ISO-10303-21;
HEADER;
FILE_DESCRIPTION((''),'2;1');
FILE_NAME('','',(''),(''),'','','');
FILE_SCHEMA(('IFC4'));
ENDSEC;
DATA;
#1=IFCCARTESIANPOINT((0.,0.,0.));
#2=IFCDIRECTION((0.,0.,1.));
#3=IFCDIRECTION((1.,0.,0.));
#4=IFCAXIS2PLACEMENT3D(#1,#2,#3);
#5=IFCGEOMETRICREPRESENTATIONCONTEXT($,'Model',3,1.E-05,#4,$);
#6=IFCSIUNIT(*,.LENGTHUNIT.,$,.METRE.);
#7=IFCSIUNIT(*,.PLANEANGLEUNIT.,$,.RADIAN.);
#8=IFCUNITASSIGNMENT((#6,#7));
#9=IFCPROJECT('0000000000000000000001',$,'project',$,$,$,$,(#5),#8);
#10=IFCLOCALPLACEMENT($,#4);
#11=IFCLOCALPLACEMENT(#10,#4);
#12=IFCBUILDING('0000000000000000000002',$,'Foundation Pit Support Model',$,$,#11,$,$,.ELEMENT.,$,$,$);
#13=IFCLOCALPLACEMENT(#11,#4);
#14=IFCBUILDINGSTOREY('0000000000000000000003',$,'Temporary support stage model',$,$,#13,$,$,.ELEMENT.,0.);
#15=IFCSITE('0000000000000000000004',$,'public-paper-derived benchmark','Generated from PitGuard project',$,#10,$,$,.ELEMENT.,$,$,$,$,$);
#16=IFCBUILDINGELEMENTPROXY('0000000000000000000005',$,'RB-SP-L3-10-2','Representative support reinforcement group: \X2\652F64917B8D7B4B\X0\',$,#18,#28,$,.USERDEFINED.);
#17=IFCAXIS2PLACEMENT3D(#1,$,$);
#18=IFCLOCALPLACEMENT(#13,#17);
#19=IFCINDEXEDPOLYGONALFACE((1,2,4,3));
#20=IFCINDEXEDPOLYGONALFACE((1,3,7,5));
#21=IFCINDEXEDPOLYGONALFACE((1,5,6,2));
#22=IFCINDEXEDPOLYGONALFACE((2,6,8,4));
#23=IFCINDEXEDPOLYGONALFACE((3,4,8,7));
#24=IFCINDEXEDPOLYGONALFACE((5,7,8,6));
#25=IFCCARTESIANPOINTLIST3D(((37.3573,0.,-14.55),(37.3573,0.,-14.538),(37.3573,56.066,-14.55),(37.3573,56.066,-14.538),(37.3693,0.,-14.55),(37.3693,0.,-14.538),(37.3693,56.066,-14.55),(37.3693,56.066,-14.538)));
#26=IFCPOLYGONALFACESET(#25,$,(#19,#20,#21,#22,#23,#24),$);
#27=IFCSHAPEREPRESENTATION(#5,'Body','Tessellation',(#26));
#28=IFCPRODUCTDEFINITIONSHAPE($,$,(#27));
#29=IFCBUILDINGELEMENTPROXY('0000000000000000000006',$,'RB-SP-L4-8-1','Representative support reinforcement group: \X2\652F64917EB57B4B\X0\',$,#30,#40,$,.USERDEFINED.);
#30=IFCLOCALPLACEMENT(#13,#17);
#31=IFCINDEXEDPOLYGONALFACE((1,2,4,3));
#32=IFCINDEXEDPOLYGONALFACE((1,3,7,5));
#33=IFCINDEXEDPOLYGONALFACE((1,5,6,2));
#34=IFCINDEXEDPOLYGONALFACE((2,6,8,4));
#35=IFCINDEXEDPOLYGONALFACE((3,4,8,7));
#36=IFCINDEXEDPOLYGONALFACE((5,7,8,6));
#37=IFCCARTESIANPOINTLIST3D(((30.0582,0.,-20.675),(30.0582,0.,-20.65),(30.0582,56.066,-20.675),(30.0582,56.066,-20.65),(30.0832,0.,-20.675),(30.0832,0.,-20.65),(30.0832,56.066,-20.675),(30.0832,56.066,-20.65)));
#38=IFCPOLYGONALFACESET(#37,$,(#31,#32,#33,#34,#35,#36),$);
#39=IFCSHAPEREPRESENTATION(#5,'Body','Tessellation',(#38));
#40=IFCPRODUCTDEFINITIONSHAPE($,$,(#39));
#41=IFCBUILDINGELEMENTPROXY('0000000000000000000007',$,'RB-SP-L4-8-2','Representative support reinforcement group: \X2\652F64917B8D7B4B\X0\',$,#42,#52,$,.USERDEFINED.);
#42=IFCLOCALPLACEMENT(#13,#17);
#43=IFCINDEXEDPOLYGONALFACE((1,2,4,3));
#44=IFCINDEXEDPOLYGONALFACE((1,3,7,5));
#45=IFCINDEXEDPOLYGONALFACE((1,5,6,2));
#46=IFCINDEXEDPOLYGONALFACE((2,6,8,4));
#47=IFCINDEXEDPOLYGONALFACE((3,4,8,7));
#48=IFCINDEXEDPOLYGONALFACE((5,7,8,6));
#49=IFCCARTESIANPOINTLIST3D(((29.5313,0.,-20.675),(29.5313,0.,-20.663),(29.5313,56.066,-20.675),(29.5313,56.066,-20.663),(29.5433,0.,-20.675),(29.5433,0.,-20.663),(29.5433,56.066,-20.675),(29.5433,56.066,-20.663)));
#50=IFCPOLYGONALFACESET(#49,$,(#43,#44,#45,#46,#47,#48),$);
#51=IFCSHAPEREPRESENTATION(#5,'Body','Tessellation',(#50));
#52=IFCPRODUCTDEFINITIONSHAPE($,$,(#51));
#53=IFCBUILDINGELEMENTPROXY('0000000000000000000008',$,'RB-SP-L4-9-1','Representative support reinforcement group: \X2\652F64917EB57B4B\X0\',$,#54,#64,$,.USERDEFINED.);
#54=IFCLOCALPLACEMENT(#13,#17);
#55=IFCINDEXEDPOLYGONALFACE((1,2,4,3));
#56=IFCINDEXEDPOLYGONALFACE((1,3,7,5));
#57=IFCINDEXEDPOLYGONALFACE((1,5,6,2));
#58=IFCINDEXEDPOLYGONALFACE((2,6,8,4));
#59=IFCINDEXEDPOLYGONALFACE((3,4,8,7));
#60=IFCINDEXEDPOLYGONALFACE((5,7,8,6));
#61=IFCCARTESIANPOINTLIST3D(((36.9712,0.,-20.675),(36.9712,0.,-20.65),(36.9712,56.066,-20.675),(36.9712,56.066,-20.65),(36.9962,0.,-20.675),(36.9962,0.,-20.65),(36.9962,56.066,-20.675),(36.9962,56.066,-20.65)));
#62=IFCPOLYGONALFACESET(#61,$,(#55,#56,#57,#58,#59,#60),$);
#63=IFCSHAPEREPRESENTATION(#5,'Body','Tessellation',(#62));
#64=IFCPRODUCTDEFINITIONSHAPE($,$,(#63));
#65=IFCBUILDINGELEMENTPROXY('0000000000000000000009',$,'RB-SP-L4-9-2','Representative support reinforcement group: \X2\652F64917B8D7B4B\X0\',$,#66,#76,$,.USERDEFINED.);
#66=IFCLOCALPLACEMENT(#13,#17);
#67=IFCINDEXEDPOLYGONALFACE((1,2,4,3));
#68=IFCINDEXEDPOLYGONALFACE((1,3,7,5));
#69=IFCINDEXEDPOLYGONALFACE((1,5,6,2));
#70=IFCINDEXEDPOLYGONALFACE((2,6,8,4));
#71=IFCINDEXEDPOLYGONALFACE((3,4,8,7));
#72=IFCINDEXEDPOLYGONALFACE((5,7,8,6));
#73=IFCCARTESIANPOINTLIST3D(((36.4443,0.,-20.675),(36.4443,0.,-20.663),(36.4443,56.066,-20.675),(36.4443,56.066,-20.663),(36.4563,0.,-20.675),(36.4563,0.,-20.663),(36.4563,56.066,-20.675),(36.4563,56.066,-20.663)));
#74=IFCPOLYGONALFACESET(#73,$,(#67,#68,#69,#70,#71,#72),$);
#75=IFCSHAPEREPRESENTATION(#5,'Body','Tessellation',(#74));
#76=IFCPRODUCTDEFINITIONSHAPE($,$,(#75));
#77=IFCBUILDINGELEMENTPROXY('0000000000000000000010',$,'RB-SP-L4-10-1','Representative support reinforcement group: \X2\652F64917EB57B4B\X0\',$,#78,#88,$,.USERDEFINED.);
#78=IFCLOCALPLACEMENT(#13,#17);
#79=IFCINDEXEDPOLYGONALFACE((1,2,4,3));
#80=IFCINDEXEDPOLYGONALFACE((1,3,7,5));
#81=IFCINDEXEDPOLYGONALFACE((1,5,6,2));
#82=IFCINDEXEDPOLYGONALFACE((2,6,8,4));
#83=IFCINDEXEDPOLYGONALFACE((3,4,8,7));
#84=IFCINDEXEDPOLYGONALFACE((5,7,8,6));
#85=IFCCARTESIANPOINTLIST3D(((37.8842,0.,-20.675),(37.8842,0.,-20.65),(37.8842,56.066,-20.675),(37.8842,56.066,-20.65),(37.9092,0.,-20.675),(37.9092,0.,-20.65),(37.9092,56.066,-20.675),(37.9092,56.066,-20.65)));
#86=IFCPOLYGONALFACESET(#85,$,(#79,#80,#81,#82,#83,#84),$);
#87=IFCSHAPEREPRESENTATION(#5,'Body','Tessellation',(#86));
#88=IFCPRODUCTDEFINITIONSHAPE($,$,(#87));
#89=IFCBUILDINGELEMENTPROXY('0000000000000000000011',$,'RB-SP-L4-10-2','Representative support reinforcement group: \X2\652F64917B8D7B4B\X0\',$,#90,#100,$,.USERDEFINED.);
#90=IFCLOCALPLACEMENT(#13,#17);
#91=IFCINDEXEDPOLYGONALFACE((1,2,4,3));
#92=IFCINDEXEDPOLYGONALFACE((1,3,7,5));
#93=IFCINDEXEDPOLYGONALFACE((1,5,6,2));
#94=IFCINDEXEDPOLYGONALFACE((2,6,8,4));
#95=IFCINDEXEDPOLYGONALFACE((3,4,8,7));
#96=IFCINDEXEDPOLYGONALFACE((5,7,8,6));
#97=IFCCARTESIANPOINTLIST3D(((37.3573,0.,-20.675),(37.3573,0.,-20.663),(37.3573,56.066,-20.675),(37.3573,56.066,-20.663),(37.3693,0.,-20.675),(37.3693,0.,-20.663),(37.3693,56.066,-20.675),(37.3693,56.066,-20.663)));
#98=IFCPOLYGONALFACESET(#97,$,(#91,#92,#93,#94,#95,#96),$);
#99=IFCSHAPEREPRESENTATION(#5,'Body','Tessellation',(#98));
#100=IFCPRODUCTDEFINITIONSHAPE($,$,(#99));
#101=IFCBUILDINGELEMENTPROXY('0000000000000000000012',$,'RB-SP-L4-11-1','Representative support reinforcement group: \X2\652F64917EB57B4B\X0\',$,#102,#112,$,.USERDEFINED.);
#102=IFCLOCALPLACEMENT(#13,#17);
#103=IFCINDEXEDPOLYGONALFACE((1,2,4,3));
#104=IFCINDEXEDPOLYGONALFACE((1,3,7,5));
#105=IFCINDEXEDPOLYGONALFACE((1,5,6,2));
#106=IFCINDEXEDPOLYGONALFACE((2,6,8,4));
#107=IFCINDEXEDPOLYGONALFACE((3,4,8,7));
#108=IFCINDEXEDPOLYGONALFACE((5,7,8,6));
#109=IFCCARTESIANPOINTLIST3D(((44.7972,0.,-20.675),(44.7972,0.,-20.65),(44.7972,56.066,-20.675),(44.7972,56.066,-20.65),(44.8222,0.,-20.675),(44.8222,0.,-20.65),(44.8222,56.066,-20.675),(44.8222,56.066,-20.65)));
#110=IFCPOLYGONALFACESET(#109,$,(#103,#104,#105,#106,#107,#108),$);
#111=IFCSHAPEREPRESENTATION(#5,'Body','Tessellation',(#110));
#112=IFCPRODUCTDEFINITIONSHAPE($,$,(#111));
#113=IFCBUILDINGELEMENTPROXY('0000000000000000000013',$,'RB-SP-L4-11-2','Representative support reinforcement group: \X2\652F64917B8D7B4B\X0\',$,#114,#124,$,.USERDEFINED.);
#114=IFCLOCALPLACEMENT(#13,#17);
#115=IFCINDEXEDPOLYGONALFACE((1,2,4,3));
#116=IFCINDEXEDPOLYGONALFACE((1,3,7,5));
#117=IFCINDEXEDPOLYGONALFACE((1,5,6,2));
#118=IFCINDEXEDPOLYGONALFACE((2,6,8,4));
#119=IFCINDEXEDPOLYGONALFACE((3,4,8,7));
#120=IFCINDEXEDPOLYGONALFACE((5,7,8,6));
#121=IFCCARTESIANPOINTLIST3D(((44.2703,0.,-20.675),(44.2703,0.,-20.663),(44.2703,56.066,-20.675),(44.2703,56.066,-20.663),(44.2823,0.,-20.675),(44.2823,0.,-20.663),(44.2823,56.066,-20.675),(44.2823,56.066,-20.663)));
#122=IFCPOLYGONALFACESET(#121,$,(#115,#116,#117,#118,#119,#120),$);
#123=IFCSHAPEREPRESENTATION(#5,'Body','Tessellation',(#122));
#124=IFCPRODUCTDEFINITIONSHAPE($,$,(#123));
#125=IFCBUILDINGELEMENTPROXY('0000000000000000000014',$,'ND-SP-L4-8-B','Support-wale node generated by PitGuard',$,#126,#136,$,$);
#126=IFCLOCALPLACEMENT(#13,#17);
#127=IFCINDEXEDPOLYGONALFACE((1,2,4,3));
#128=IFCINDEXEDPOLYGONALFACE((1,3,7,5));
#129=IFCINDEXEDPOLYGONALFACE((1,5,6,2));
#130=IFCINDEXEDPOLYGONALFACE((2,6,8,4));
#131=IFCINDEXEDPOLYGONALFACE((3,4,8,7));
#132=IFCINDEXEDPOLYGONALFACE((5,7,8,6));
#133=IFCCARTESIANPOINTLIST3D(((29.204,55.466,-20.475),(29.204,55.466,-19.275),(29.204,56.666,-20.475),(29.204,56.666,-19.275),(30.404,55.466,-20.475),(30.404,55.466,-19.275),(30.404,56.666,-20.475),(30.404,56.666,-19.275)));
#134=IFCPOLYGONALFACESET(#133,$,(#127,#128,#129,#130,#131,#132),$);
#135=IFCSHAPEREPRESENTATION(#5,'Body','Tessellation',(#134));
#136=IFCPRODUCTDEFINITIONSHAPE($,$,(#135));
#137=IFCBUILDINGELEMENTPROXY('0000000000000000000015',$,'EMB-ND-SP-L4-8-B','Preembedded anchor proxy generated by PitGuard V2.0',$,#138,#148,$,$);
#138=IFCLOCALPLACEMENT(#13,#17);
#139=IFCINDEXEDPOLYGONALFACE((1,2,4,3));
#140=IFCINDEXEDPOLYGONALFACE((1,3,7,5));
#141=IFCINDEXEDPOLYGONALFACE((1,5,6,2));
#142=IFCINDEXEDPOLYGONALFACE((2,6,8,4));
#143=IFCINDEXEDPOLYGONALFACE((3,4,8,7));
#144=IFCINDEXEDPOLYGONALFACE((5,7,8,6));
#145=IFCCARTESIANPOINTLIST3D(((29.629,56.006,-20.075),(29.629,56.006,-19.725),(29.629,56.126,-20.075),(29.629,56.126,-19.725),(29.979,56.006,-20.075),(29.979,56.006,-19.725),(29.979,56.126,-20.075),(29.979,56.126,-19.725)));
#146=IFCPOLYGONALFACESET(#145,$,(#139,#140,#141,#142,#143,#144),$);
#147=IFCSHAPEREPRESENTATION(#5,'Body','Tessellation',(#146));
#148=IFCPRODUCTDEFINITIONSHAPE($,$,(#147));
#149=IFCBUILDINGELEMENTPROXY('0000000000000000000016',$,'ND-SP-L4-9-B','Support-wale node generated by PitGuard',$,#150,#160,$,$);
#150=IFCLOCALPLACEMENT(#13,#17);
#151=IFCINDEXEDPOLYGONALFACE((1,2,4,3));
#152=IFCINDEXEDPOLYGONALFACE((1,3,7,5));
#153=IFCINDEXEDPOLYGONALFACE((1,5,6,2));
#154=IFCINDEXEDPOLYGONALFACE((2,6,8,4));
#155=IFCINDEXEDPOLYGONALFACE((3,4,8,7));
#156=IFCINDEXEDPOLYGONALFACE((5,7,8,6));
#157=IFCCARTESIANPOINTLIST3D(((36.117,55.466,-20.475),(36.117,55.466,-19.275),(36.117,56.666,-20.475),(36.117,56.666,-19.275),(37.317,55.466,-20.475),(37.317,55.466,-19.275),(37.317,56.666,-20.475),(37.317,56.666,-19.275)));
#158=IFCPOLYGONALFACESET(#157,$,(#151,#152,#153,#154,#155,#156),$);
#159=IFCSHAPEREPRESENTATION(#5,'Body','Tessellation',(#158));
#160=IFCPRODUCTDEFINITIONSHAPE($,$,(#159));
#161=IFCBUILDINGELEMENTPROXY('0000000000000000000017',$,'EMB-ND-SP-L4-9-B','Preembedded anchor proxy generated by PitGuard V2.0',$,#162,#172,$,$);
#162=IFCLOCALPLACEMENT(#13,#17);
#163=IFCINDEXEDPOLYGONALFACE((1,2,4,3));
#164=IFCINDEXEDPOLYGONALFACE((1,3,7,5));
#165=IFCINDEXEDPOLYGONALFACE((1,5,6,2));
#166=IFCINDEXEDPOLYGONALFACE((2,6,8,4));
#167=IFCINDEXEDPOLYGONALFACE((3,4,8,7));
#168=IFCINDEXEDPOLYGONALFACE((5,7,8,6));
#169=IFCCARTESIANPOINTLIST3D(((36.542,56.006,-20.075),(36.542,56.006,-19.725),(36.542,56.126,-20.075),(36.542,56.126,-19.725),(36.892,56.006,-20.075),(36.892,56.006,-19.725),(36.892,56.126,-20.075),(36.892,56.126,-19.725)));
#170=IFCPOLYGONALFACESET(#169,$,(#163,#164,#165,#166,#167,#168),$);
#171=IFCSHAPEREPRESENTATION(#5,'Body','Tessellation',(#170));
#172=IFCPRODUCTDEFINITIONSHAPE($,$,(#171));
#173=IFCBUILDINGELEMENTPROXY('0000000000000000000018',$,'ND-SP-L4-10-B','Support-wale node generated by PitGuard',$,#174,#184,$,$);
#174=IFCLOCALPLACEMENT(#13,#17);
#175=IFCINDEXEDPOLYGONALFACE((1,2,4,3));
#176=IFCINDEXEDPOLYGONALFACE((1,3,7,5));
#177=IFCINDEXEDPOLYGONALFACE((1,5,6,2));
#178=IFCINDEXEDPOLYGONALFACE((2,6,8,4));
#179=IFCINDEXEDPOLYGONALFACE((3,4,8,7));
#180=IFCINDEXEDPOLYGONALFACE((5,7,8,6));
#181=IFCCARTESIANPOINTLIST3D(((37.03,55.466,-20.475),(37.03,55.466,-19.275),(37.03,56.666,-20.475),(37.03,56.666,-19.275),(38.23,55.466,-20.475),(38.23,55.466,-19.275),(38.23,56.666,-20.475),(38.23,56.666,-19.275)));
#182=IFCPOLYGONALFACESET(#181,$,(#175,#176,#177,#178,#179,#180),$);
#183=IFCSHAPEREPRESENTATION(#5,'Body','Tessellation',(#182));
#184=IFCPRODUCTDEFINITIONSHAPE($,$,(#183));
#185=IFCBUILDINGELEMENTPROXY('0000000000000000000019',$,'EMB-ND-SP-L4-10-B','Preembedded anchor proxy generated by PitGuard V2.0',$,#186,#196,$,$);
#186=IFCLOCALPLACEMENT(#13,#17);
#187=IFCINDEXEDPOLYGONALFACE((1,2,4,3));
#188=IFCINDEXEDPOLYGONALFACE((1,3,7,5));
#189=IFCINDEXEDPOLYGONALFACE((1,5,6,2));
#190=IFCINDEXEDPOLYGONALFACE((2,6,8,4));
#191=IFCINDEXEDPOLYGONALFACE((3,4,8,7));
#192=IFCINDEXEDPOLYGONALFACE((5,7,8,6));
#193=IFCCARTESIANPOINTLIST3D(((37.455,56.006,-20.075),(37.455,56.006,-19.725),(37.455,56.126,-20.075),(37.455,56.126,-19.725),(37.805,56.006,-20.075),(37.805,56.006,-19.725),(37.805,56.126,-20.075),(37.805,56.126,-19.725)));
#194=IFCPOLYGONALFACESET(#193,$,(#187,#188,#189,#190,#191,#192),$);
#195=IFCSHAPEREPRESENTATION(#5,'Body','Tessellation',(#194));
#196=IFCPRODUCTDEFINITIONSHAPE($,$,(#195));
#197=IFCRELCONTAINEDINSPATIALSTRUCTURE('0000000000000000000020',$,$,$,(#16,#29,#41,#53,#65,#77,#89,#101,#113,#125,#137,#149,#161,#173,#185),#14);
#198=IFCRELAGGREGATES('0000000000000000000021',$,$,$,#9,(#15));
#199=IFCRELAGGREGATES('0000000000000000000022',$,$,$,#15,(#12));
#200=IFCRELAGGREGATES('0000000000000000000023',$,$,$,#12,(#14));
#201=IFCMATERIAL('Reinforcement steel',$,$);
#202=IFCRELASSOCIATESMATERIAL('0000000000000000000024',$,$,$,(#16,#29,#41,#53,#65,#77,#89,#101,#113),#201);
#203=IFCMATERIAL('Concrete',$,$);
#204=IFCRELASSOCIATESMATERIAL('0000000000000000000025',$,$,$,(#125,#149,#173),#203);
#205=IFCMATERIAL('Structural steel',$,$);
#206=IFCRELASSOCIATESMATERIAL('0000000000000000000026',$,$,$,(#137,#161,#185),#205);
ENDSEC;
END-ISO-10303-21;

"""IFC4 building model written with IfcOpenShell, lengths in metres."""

from ifc_helpers import new_model, si_unit, frame, origin_with_axes, origin_2d, place, context, project, spatial, rectangle, extrude, material, element, save


model = new_model("IFC4")

# Units and contexts
model_context = context("Model", 3, precision=1e-05, world=origin_with_axes())
ifc_project = project(units=[si_unit("LENGTHUNIT", "METRE"), si_unit("PLANEANGLEUNIT", "RADIAN")], contexts=[model_context])

# Site, building, storey
site_placement = place(None, origin_with_axes())
site = spatial("IfcSite", under=ifc_project, at=site_placement, Name="public-paper-derived benchmark", Description="Generated from PitGuard project", CompositionType="ELEMENT")
building_placement = place(site_placement, origin_with_axes())
building = spatial("IfcBuilding", under=site, at=building_placement, Name="Foundation Pit Support Model", CompositionType="ELEMENT")
storey_placement = place(building_placement, origin_with_axes())
storey = spatial("IfcBuildingStorey", under=building, at=storey_placement, Name="Temporary support stage model", CompositionType="ELEMENT", Elevation=0.0)

# Shared definitions
ifc_material_1 = material(Name="Concrete")

# Shared definitions
ifc_material_2 = material(Name="Structural steel")

# Building element proxies
ifc_material_3 = material(Name="Reinforcement steel")
for number, where, z_axis, x_axis, name in (
    (1, (37.3633, 28.033, -14.55), (0.0, 0.0, 1.0), (0.0, 1.0, 0.0), "RB-SP-L3-10-2"),
):
    element("IfcBuildingElementProxy", number, at=place(storey_placement, frame(where, z_axis=z_axis, x_axis=x_axis)), inside=storey, material=ifc_material_3, Name=name, Description="Representative support reinforcement group: 支撑箍筋", PredefinedType="USERDEFINED", context=model_context, shape_type="SweptSolid", body=[
        extrude(rectangle(XDim=56.066, YDim=0.012, at=origin_2d()), origin_with_axes(), (0.0, 0.0, 1.0), 0.012),
    ])
proxy_1_placement = place(storey_placement, frame((30.0707, 28.033, -20.675), z_axis=(0.0, 0.0, 1.0), x_axis=(0.0, 1.0, 0.0)))
element("IfcBuildingElementProxy", 2, at=proxy_1_placement, inside=storey, material=ifc_material_3, Name="RB-SP-L4-8-1", Description="Representative support reinforcement group: 支撑纵筋", PredefinedType="USERDEFINED", context=model_context, shape_type="SweptSolid", body=[
    extrude(rectangle(XDim=56.066, YDim=0.025, at=origin_2d()), origin_with_axes(), (0.0, 0.0, 1.0), 0.025),
])
proxy_2_placement = place(storey_placement, frame((29.5373, 28.033, -20.675), z_axis=(0.0, 0.0, 1.0), x_axis=(0.0, 1.0, 0.0)))
element("IfcBuildingElementProxy", 3, at=proxy_2_placement, inside=storey, material=ifc_material_3, Name="RB-SP-L4-8-2", Description="Representative support reinforcement group: 支撑箍筋", PredefinedType="USERDEFINED", context=model_context, shape_type="SweptSolid", body=[
    extrude(rectangle(XDim=56.066, YDim=0.012, at=origin_2d()), origin_with_axes(), (0.0, 0.0, 1.0), 0.012),
])
proxy_3_placement = place(storey_placement, frame((36.9837, 28.033, -20.675), z_axis=(0.0, 0.0, 1.0), x_axis=(0.0, 1.0, 0.0)))
element("IfcBuildingElementProxy", 4, at=proxy_3_placement, inside=storey, material=ifc_material_3, Name="RB-SP-L4-9-1", Description="Representative support reinforcement group: 支撑纵筋", PredefinedType="USERDEFINED", context=model_context, shape_type="SweptSolid", body=[
    extrude(rectangle(XDim=56.066, YDim=0.025, at=origin_2d()), origin_with_axes(), (0.0, 0.0, 1.0), 0.025),
])
proxy_4_placement = place(storey_placement, frame((36.4503, 28.033, -20.675), z_axis=(0.0, 0.0, 1.0), x_axis=(0.0, 1.0, 0.0)))
element("IfcBuildingElementProxy", 5, at=proxy_4_placement, inside=storey, material=ifc_material_3, Name="RB-SP-L4-9-2", Description="Representative support reinforcement group: 支撑箍筋", PredefinedType="USERDEFINED", context=model_context, shape_type="SweptSolid", body=[
    extrude(rectangle(XDim=56.066, YDim=0.012, at=origin_2d()), origin_with_axes(), (0.0, 0.0, 1.0), 0.012),
])
proxy_5_placement = place(storey_placement, frame((37.8967, 28.033, -20.675), z_axis=(0.0, 0.0, 1.0), x_axis=(0.0, 1.0, 0.0)))
element("IfcBuildingElementProxy", 6, at=proxy_5_placement, inside=storey, material=ifc_material_3, Name="RB-SP-L4-10-1", Description="Representative support reinforcement group: 支撑纵筋", PredefinedType="USERDEFINED", context=model_context, shape_type="SweptSolid", body=[
    extrude(rectangle(XDim=56.066, YDim=0.025, at=origin_2d()), origin_with_axes(), (0.0, 0.0, 1.0), 0.025),
])
proxy_6_placement = place(storey_placement, frame((37.3633, 28.033, -20.675), z_axis=(0.0, 0.0, 1.0), x_axis=(0.0, 1.0, 0.0)))
element("IfcBuildingElementProxy", 7, at=proxy_6_placement, inside=storey, material=ifc_material_3, Name="RB-SP-L4-10-2", Description="Representative support reinforcement group: 支撑箍筋", PredefinedType="USERDEFINED", context=model_context, shape_type="SweptSolid", body=[
    extrude(rectangle(XDim=56.066, YDim=0.012, at=origin_2d()), origin_with_axes(), (0.0, 0.0, 1.0), 0.012),
])
proxy_7_placement = place(storey_placement, frame((44.8097, 28.033, -20.675), z_axis=(0.0, 0.0, 1.0), x_axis=(0.0, 1.0, 0.0)))
element("IfcBuildingElementProxy", 8, at=proxy_7_placement, inside=storey, material=ifc_material_3, Name="RB-SP-L4-11-1", Description="Representative support reinforcement group: 支撑纵筋", PredefinedType="USERDEFINED", context=model_context, shape_type="SweptSolid", body=[
    extrude(rectangle(XDim=56.066, YDim=0.025, at=origin_2d()), origin_with_axes(), (0.0, 0.0, 1.0), 0.025),
])
proxy_8_placement = place(storey_placement, frame((44.2763, 28.033, -20.675), z_axis=(0.0, 0.0, 1.0), x_axis=(0.0, 1.0, 0.0)))
element("IfcBuildingElementProxy", 9, at=proxy_8_placement, inside=storey, material=ifc_material_3, Name="RB-SP-L4-11-2", Description="Representative support reinforcement group: 支撑箍筋", PredefinedType="USERDEFINED", context=model_context, shape_type="SweptSolid", body=[
    extrude(rectangle(XDim=56.066, YDim=0.012, at=origin_2d()), origin_with_axes(), (0.0, 0.0, 1.0), 0.012),
])
proxy_9_placement = place(storey_placement, frame((29.804, 56.066, -20.475), z_axis=(0.0, 0.0, 1.0), x_axis=(1.0, 0.0, 0.0)))
element("IfcBuildingElementProxy", 10, at=proxy_9_placement, inside=storey, material=ifc_material_1, Name="ND-SP-L4-8-B", Description="Support-wale node generated by PitGuard", context=model_context, shape_type="SweptSolid", body=[
    extrude(rectangle(XDim=1.2, YDim=1.2, at=origin_2d()), origin_with_axes(), (0.0, 0.0, 1.0), 1.2),
])
proxy_10_placement = place(storey_placement, frame((29.804, 56.066, -20.075), z_axis=(0.0, 0.0, 1.0), x_axis=(1.0, 0.0, 0.0)))
element("IfcBuildingElementProxy", 11, at=proxy_10_placement, inside=storey, material=ifc_material_2, Name="EMB-ND-SP-L4-8-B", Description="Preembedded anchor proxy generated by PitGuard V2.0", context=model_context, shape_type="SweptSolid", body=[
    extrude(rectangle(XDim=0.35, YDim=0.12, at=origin_2d()), origin_with_axes(), (0.0, 0.0, 1.0), 0.35),
])
proxy_11_placement = place(storey_placement, frame((36.717, 56.066, -20.475), z_axis=(0.0, 0.0, 1.0), x_axis=(1.0, 0.0, 0.0)))
element("IfcBuildingElementProxy", 12, at=proxy_11_placement, inside=storey, material=ifc_material_1, Name="ND-SP-L4-9-B", Description="Support-wale node generated by PitGuard", context=model_context, shape_type="SweptSolid", body=[
    extrude(rectangle(XDim=1.2, YDim=1.2, at=origin_2d()), origin_with_axes(), (0.0, 0.0, 1.0), 1.2),
])
proxy_12_placement = place(storey_placement, frame((36.717, 56.066, -20.075), z_axis=(0.0, 0.0, 1.0), x_axis=(1.0, 0.0, 0.0)))
element("IfcBuildingElementProxy", 13, at=proxy_12_placement, inside=storey, material=ifc_material_2, Name="EMB-ND-SP-L4-9-B", Description="Preembedded anchor proxy generated by PitGuard V2.0", context=model_context, shape_type="SweptSolid", body=[
    extrude(rectangle(XDim=0.35, YDim=0.12, at=origin_2d()), origin_with_axes(), (0.0, 0.0, 1.0), 0.35),
])
proxy_13_placement = place(storey_placement, frame((37.63, 56.066, -20.475), z_axis=(0.0, 0.0, 1.0), x_axis=(1.0, 0.0, 0.0)))
element("IfcBuildingElementProxy", 14, at=proxy_13_placement, inside=storey, material=ifc_material_1, Name="ND-SP-L4-10-B", Description="Support-wale node generated by PitGuard", context=model_context, shape_type="SweptSolid", body=[
    extrude(rectangle(XDim=1.2, YDim=1.2, at=origin_2d()), origin_with_axes(), (0.0, 0.0, 1.0), 1.2),
])
proxy_14_placement = place(storey_placement, frame((37.63, 56.066, -20.075), z_axis=(0.0, 0.0, 1.0), x_axis=(1.0, 0.0, 0.0)))
element("IfcBuildingElementProxy", 15, at=proxy_14_placement, inside=storey, material=ifc_material_2, Name="EMB-ND-SP-L4-10-B", Description="Preembedded anchor proxy generated by PitGuard V2.0", context=model_context, shape_type="SweptSolid", body=[
    extrude(rectangle(XDim=0.35, YDim=0.12, at=origin_2d()), origin_with_axes(), (0.0, 0.0, 1.0), 0.35),
])

save(model, "model.ifc")
